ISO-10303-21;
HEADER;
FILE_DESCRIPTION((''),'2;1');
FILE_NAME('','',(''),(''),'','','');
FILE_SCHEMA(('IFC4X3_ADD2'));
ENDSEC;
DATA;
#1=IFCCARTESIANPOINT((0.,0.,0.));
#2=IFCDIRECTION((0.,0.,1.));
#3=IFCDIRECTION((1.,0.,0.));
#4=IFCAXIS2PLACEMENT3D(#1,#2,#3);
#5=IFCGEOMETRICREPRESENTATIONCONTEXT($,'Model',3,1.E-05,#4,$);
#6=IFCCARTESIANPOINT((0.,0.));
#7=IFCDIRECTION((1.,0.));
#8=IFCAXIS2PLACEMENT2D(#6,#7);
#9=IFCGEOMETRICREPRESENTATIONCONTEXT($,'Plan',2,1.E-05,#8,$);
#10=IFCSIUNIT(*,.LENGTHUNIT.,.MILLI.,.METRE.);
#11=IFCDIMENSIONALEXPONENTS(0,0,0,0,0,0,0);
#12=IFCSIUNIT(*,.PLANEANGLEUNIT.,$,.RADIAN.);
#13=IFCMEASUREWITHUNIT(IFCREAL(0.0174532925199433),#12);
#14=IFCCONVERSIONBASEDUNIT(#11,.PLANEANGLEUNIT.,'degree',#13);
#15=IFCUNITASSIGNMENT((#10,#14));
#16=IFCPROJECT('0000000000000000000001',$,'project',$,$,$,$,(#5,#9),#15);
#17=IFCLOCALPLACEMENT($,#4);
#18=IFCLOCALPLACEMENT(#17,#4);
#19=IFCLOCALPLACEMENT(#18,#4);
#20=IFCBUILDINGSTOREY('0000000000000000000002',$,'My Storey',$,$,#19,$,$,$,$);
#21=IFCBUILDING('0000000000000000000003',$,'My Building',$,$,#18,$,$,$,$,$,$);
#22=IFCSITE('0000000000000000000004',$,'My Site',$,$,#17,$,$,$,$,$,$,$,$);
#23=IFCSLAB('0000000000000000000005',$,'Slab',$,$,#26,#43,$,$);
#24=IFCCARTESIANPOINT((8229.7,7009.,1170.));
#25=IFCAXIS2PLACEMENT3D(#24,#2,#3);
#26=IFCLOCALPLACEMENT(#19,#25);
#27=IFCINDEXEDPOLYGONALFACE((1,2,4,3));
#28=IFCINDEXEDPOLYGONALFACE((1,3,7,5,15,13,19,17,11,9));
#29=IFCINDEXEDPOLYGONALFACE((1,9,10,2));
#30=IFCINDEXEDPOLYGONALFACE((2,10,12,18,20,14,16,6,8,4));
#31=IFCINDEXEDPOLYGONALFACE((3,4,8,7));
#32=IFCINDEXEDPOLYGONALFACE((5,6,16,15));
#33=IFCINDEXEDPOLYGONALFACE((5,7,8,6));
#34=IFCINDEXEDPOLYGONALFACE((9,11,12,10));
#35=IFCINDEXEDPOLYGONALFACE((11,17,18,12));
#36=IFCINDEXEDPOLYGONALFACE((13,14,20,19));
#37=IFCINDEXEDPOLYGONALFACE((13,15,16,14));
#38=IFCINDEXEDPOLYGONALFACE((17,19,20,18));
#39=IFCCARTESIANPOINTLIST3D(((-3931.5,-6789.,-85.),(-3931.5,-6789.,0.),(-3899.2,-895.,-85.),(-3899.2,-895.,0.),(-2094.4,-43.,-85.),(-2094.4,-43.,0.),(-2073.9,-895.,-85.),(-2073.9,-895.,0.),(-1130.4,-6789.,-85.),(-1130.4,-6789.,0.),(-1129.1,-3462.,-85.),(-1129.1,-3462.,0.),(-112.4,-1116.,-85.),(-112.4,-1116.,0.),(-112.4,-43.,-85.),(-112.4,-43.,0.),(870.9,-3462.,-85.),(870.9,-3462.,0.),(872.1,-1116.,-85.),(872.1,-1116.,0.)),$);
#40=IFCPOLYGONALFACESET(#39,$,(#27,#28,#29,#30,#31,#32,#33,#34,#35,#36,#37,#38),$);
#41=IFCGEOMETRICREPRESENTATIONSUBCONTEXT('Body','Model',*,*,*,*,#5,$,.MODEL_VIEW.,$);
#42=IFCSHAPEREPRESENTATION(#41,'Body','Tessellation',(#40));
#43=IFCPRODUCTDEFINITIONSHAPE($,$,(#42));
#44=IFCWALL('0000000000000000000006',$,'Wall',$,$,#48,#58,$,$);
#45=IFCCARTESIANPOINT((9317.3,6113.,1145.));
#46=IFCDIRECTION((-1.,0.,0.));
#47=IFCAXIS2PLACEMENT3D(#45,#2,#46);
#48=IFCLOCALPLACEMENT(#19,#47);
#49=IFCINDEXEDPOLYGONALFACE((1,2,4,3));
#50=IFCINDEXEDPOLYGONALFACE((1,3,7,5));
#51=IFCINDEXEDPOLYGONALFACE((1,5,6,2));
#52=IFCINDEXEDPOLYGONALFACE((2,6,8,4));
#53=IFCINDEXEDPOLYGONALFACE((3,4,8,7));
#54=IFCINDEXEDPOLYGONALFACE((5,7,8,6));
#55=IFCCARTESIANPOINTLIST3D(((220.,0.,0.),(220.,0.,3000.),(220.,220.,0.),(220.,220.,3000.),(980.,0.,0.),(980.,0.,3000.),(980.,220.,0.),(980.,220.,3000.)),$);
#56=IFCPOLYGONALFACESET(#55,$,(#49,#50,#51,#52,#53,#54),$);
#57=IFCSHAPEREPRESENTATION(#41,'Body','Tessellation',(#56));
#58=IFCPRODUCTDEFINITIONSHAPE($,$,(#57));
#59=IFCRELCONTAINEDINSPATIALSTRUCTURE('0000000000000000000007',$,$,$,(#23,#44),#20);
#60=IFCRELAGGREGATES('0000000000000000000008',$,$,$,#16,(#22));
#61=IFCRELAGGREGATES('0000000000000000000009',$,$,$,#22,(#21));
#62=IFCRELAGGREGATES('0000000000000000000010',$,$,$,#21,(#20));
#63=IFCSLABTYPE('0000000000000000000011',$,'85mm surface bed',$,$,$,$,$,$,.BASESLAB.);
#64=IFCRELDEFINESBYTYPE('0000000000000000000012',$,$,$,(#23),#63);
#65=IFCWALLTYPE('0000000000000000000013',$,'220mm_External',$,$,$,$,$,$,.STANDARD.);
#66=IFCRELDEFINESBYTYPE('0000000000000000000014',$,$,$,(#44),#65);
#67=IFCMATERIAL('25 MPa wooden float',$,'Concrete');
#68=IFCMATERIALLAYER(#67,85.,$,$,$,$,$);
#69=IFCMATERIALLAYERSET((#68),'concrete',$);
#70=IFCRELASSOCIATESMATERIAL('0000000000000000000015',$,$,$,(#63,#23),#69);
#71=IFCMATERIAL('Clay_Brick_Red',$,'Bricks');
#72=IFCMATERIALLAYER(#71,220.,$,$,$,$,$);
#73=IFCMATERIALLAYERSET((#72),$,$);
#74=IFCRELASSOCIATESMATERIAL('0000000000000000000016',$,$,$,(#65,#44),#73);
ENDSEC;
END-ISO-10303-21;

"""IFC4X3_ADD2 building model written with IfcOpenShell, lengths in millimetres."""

from ifc_helpers import new_model, entity, si_unit, converted_unit, frame, origin_with_axes, origin_2d_with_axis, place, context, subcontext, project, spatial, line, indexed_curve, outline, extrude, material, layer, layer_set, layer_usage, type_object, element, save


model = new_model("IFC4X3_ADD2")

# Units and contexts
model_context = context("Model", 3, precision=1e-05, world=origin_with_axes())
plan_context = context("Plan", 2, precision=1e-05, world=origin_2d_with_axis())
body_context_1 = subcontext(model_context, "Body", "Model", "MODEL_VIEW")
ifc_project = project(units=[si_unit("LENGTHUNIT", "METRE", prefix="MILLI"), converted_unit("PLANEANGLEUNIT", "degree", entity("IfcReal", 0.0174532925199433), si_unit("PLANEANGLEUNIT", "RADIAN"), dimensions=[0, 0, 0, 0, 0, 0, 0])], contexts=[model_context, plan_context])

# Site, building, storey
site_placement = place(None, origin_with_axes())
site = spatial("IfcSite", under=ifc_project, at=site_placement, Name="My Site")
building_placement = place(site_placement, origin_with_axes())
building = spatial("IfcBuilding", under=site, at=building_placement, Name="My Building")
storey_placement = place(building_placement, origin_with_axes())
storey = spatial("IfcBuildingStorey", under=building, at=storey_placement, Name="My Storey")

# Slab
ifc_material_1 = material(Name="25 MPa wooden float", Category="Concrete")
ifc_layer_1 = layer(ifc_material_1, 85.0)
ifc_layer_set_1 = layer_set([ifc_layer_1], Name="concrete")
ifc_layer_usage_1 = layer_usage(ifc_layer_set_1, "AXIS3", "POSITIVE", -85.0)
slab_type = type_object("IfcSlabType", Name="85mm surface bed", PredefinedType="BASESLAB", material=ifc_layer_set_1)
slab_placement = place(storey_placement, frame((8229.7, 7009.0, 1170.0), z_axis=(0.0, 0.0, 1.0), x_axis=(1.0, 0.0, 0.0)))
element("IfcSlab", 1, at=slab_placement, inside=storey, type_object=slab_type, material=ifc_layer_usage_1, Name="Slab", context=body_context_1, shape_type="SweptSolid", body=[
    extrude(outline(indexed_curve([(-1129.1, -3462.0), (870.9, -3462.0), (872.1, -1116.0), (-112.4, -1116.0), (-112.4, -43.0), (-2094.4, -43.0), (-2073.9, -895.0), (-3899.2, -895.0), (-3931.5, -6789.0), (-1130.4, -6789.0), (-1129.1, -3462.0)])), frame((0.0, 0.0, -85.0), z_axis=(0.0, 0.0, 1.0), x_axis=(1.0, 0.0, 0.0)), (0.0, 0.0, 1.0), 85.0),
])

# Shared definitions
ifc_material_2 = material(Name="Clay_Brick_Red", Category="Bricks")
ifc_layer_2 = layer(ifc_material_2, 220.0)
ifc_layer_set_2 = layer_set([ifc_layer_2])
wall_type_1 = type_object("IfcWallType", Name="220mm_External", PredefinedType="STANDARD", material=ifc_layer_set_2)

# Wall
ifc_layer_usage_2 = layer_usage(ifc_layer_set_2, "AXIS2", "POSITIVE", 0.0)
wall_1_placement = place(storey_placement, frame((9317.3, 6113.0, 1145.0), z_axis=(0.0, 0.0, 1.0), x_axis=(-1.0, 0.0, 0.0)))
element("IfcWall", 2, at=wall_1_placement, inside=storey, type_object=wall_type_1, material=ifc_layer_usage_2, Name="Wall", context=body_context_1, shape_type="SweptSolid", body=[
    extrude(outline(indexed_curve([(220.0, 0.0), (220.0, 220.0), (980.0, 220.0), (980.0, 0.0)], segments=[line(1, 2, 3, 4, 1)])), origin_with_axes(), (0.0, 0.0, 1.0), 3000.0),
])

save(model, "model.ifc")
